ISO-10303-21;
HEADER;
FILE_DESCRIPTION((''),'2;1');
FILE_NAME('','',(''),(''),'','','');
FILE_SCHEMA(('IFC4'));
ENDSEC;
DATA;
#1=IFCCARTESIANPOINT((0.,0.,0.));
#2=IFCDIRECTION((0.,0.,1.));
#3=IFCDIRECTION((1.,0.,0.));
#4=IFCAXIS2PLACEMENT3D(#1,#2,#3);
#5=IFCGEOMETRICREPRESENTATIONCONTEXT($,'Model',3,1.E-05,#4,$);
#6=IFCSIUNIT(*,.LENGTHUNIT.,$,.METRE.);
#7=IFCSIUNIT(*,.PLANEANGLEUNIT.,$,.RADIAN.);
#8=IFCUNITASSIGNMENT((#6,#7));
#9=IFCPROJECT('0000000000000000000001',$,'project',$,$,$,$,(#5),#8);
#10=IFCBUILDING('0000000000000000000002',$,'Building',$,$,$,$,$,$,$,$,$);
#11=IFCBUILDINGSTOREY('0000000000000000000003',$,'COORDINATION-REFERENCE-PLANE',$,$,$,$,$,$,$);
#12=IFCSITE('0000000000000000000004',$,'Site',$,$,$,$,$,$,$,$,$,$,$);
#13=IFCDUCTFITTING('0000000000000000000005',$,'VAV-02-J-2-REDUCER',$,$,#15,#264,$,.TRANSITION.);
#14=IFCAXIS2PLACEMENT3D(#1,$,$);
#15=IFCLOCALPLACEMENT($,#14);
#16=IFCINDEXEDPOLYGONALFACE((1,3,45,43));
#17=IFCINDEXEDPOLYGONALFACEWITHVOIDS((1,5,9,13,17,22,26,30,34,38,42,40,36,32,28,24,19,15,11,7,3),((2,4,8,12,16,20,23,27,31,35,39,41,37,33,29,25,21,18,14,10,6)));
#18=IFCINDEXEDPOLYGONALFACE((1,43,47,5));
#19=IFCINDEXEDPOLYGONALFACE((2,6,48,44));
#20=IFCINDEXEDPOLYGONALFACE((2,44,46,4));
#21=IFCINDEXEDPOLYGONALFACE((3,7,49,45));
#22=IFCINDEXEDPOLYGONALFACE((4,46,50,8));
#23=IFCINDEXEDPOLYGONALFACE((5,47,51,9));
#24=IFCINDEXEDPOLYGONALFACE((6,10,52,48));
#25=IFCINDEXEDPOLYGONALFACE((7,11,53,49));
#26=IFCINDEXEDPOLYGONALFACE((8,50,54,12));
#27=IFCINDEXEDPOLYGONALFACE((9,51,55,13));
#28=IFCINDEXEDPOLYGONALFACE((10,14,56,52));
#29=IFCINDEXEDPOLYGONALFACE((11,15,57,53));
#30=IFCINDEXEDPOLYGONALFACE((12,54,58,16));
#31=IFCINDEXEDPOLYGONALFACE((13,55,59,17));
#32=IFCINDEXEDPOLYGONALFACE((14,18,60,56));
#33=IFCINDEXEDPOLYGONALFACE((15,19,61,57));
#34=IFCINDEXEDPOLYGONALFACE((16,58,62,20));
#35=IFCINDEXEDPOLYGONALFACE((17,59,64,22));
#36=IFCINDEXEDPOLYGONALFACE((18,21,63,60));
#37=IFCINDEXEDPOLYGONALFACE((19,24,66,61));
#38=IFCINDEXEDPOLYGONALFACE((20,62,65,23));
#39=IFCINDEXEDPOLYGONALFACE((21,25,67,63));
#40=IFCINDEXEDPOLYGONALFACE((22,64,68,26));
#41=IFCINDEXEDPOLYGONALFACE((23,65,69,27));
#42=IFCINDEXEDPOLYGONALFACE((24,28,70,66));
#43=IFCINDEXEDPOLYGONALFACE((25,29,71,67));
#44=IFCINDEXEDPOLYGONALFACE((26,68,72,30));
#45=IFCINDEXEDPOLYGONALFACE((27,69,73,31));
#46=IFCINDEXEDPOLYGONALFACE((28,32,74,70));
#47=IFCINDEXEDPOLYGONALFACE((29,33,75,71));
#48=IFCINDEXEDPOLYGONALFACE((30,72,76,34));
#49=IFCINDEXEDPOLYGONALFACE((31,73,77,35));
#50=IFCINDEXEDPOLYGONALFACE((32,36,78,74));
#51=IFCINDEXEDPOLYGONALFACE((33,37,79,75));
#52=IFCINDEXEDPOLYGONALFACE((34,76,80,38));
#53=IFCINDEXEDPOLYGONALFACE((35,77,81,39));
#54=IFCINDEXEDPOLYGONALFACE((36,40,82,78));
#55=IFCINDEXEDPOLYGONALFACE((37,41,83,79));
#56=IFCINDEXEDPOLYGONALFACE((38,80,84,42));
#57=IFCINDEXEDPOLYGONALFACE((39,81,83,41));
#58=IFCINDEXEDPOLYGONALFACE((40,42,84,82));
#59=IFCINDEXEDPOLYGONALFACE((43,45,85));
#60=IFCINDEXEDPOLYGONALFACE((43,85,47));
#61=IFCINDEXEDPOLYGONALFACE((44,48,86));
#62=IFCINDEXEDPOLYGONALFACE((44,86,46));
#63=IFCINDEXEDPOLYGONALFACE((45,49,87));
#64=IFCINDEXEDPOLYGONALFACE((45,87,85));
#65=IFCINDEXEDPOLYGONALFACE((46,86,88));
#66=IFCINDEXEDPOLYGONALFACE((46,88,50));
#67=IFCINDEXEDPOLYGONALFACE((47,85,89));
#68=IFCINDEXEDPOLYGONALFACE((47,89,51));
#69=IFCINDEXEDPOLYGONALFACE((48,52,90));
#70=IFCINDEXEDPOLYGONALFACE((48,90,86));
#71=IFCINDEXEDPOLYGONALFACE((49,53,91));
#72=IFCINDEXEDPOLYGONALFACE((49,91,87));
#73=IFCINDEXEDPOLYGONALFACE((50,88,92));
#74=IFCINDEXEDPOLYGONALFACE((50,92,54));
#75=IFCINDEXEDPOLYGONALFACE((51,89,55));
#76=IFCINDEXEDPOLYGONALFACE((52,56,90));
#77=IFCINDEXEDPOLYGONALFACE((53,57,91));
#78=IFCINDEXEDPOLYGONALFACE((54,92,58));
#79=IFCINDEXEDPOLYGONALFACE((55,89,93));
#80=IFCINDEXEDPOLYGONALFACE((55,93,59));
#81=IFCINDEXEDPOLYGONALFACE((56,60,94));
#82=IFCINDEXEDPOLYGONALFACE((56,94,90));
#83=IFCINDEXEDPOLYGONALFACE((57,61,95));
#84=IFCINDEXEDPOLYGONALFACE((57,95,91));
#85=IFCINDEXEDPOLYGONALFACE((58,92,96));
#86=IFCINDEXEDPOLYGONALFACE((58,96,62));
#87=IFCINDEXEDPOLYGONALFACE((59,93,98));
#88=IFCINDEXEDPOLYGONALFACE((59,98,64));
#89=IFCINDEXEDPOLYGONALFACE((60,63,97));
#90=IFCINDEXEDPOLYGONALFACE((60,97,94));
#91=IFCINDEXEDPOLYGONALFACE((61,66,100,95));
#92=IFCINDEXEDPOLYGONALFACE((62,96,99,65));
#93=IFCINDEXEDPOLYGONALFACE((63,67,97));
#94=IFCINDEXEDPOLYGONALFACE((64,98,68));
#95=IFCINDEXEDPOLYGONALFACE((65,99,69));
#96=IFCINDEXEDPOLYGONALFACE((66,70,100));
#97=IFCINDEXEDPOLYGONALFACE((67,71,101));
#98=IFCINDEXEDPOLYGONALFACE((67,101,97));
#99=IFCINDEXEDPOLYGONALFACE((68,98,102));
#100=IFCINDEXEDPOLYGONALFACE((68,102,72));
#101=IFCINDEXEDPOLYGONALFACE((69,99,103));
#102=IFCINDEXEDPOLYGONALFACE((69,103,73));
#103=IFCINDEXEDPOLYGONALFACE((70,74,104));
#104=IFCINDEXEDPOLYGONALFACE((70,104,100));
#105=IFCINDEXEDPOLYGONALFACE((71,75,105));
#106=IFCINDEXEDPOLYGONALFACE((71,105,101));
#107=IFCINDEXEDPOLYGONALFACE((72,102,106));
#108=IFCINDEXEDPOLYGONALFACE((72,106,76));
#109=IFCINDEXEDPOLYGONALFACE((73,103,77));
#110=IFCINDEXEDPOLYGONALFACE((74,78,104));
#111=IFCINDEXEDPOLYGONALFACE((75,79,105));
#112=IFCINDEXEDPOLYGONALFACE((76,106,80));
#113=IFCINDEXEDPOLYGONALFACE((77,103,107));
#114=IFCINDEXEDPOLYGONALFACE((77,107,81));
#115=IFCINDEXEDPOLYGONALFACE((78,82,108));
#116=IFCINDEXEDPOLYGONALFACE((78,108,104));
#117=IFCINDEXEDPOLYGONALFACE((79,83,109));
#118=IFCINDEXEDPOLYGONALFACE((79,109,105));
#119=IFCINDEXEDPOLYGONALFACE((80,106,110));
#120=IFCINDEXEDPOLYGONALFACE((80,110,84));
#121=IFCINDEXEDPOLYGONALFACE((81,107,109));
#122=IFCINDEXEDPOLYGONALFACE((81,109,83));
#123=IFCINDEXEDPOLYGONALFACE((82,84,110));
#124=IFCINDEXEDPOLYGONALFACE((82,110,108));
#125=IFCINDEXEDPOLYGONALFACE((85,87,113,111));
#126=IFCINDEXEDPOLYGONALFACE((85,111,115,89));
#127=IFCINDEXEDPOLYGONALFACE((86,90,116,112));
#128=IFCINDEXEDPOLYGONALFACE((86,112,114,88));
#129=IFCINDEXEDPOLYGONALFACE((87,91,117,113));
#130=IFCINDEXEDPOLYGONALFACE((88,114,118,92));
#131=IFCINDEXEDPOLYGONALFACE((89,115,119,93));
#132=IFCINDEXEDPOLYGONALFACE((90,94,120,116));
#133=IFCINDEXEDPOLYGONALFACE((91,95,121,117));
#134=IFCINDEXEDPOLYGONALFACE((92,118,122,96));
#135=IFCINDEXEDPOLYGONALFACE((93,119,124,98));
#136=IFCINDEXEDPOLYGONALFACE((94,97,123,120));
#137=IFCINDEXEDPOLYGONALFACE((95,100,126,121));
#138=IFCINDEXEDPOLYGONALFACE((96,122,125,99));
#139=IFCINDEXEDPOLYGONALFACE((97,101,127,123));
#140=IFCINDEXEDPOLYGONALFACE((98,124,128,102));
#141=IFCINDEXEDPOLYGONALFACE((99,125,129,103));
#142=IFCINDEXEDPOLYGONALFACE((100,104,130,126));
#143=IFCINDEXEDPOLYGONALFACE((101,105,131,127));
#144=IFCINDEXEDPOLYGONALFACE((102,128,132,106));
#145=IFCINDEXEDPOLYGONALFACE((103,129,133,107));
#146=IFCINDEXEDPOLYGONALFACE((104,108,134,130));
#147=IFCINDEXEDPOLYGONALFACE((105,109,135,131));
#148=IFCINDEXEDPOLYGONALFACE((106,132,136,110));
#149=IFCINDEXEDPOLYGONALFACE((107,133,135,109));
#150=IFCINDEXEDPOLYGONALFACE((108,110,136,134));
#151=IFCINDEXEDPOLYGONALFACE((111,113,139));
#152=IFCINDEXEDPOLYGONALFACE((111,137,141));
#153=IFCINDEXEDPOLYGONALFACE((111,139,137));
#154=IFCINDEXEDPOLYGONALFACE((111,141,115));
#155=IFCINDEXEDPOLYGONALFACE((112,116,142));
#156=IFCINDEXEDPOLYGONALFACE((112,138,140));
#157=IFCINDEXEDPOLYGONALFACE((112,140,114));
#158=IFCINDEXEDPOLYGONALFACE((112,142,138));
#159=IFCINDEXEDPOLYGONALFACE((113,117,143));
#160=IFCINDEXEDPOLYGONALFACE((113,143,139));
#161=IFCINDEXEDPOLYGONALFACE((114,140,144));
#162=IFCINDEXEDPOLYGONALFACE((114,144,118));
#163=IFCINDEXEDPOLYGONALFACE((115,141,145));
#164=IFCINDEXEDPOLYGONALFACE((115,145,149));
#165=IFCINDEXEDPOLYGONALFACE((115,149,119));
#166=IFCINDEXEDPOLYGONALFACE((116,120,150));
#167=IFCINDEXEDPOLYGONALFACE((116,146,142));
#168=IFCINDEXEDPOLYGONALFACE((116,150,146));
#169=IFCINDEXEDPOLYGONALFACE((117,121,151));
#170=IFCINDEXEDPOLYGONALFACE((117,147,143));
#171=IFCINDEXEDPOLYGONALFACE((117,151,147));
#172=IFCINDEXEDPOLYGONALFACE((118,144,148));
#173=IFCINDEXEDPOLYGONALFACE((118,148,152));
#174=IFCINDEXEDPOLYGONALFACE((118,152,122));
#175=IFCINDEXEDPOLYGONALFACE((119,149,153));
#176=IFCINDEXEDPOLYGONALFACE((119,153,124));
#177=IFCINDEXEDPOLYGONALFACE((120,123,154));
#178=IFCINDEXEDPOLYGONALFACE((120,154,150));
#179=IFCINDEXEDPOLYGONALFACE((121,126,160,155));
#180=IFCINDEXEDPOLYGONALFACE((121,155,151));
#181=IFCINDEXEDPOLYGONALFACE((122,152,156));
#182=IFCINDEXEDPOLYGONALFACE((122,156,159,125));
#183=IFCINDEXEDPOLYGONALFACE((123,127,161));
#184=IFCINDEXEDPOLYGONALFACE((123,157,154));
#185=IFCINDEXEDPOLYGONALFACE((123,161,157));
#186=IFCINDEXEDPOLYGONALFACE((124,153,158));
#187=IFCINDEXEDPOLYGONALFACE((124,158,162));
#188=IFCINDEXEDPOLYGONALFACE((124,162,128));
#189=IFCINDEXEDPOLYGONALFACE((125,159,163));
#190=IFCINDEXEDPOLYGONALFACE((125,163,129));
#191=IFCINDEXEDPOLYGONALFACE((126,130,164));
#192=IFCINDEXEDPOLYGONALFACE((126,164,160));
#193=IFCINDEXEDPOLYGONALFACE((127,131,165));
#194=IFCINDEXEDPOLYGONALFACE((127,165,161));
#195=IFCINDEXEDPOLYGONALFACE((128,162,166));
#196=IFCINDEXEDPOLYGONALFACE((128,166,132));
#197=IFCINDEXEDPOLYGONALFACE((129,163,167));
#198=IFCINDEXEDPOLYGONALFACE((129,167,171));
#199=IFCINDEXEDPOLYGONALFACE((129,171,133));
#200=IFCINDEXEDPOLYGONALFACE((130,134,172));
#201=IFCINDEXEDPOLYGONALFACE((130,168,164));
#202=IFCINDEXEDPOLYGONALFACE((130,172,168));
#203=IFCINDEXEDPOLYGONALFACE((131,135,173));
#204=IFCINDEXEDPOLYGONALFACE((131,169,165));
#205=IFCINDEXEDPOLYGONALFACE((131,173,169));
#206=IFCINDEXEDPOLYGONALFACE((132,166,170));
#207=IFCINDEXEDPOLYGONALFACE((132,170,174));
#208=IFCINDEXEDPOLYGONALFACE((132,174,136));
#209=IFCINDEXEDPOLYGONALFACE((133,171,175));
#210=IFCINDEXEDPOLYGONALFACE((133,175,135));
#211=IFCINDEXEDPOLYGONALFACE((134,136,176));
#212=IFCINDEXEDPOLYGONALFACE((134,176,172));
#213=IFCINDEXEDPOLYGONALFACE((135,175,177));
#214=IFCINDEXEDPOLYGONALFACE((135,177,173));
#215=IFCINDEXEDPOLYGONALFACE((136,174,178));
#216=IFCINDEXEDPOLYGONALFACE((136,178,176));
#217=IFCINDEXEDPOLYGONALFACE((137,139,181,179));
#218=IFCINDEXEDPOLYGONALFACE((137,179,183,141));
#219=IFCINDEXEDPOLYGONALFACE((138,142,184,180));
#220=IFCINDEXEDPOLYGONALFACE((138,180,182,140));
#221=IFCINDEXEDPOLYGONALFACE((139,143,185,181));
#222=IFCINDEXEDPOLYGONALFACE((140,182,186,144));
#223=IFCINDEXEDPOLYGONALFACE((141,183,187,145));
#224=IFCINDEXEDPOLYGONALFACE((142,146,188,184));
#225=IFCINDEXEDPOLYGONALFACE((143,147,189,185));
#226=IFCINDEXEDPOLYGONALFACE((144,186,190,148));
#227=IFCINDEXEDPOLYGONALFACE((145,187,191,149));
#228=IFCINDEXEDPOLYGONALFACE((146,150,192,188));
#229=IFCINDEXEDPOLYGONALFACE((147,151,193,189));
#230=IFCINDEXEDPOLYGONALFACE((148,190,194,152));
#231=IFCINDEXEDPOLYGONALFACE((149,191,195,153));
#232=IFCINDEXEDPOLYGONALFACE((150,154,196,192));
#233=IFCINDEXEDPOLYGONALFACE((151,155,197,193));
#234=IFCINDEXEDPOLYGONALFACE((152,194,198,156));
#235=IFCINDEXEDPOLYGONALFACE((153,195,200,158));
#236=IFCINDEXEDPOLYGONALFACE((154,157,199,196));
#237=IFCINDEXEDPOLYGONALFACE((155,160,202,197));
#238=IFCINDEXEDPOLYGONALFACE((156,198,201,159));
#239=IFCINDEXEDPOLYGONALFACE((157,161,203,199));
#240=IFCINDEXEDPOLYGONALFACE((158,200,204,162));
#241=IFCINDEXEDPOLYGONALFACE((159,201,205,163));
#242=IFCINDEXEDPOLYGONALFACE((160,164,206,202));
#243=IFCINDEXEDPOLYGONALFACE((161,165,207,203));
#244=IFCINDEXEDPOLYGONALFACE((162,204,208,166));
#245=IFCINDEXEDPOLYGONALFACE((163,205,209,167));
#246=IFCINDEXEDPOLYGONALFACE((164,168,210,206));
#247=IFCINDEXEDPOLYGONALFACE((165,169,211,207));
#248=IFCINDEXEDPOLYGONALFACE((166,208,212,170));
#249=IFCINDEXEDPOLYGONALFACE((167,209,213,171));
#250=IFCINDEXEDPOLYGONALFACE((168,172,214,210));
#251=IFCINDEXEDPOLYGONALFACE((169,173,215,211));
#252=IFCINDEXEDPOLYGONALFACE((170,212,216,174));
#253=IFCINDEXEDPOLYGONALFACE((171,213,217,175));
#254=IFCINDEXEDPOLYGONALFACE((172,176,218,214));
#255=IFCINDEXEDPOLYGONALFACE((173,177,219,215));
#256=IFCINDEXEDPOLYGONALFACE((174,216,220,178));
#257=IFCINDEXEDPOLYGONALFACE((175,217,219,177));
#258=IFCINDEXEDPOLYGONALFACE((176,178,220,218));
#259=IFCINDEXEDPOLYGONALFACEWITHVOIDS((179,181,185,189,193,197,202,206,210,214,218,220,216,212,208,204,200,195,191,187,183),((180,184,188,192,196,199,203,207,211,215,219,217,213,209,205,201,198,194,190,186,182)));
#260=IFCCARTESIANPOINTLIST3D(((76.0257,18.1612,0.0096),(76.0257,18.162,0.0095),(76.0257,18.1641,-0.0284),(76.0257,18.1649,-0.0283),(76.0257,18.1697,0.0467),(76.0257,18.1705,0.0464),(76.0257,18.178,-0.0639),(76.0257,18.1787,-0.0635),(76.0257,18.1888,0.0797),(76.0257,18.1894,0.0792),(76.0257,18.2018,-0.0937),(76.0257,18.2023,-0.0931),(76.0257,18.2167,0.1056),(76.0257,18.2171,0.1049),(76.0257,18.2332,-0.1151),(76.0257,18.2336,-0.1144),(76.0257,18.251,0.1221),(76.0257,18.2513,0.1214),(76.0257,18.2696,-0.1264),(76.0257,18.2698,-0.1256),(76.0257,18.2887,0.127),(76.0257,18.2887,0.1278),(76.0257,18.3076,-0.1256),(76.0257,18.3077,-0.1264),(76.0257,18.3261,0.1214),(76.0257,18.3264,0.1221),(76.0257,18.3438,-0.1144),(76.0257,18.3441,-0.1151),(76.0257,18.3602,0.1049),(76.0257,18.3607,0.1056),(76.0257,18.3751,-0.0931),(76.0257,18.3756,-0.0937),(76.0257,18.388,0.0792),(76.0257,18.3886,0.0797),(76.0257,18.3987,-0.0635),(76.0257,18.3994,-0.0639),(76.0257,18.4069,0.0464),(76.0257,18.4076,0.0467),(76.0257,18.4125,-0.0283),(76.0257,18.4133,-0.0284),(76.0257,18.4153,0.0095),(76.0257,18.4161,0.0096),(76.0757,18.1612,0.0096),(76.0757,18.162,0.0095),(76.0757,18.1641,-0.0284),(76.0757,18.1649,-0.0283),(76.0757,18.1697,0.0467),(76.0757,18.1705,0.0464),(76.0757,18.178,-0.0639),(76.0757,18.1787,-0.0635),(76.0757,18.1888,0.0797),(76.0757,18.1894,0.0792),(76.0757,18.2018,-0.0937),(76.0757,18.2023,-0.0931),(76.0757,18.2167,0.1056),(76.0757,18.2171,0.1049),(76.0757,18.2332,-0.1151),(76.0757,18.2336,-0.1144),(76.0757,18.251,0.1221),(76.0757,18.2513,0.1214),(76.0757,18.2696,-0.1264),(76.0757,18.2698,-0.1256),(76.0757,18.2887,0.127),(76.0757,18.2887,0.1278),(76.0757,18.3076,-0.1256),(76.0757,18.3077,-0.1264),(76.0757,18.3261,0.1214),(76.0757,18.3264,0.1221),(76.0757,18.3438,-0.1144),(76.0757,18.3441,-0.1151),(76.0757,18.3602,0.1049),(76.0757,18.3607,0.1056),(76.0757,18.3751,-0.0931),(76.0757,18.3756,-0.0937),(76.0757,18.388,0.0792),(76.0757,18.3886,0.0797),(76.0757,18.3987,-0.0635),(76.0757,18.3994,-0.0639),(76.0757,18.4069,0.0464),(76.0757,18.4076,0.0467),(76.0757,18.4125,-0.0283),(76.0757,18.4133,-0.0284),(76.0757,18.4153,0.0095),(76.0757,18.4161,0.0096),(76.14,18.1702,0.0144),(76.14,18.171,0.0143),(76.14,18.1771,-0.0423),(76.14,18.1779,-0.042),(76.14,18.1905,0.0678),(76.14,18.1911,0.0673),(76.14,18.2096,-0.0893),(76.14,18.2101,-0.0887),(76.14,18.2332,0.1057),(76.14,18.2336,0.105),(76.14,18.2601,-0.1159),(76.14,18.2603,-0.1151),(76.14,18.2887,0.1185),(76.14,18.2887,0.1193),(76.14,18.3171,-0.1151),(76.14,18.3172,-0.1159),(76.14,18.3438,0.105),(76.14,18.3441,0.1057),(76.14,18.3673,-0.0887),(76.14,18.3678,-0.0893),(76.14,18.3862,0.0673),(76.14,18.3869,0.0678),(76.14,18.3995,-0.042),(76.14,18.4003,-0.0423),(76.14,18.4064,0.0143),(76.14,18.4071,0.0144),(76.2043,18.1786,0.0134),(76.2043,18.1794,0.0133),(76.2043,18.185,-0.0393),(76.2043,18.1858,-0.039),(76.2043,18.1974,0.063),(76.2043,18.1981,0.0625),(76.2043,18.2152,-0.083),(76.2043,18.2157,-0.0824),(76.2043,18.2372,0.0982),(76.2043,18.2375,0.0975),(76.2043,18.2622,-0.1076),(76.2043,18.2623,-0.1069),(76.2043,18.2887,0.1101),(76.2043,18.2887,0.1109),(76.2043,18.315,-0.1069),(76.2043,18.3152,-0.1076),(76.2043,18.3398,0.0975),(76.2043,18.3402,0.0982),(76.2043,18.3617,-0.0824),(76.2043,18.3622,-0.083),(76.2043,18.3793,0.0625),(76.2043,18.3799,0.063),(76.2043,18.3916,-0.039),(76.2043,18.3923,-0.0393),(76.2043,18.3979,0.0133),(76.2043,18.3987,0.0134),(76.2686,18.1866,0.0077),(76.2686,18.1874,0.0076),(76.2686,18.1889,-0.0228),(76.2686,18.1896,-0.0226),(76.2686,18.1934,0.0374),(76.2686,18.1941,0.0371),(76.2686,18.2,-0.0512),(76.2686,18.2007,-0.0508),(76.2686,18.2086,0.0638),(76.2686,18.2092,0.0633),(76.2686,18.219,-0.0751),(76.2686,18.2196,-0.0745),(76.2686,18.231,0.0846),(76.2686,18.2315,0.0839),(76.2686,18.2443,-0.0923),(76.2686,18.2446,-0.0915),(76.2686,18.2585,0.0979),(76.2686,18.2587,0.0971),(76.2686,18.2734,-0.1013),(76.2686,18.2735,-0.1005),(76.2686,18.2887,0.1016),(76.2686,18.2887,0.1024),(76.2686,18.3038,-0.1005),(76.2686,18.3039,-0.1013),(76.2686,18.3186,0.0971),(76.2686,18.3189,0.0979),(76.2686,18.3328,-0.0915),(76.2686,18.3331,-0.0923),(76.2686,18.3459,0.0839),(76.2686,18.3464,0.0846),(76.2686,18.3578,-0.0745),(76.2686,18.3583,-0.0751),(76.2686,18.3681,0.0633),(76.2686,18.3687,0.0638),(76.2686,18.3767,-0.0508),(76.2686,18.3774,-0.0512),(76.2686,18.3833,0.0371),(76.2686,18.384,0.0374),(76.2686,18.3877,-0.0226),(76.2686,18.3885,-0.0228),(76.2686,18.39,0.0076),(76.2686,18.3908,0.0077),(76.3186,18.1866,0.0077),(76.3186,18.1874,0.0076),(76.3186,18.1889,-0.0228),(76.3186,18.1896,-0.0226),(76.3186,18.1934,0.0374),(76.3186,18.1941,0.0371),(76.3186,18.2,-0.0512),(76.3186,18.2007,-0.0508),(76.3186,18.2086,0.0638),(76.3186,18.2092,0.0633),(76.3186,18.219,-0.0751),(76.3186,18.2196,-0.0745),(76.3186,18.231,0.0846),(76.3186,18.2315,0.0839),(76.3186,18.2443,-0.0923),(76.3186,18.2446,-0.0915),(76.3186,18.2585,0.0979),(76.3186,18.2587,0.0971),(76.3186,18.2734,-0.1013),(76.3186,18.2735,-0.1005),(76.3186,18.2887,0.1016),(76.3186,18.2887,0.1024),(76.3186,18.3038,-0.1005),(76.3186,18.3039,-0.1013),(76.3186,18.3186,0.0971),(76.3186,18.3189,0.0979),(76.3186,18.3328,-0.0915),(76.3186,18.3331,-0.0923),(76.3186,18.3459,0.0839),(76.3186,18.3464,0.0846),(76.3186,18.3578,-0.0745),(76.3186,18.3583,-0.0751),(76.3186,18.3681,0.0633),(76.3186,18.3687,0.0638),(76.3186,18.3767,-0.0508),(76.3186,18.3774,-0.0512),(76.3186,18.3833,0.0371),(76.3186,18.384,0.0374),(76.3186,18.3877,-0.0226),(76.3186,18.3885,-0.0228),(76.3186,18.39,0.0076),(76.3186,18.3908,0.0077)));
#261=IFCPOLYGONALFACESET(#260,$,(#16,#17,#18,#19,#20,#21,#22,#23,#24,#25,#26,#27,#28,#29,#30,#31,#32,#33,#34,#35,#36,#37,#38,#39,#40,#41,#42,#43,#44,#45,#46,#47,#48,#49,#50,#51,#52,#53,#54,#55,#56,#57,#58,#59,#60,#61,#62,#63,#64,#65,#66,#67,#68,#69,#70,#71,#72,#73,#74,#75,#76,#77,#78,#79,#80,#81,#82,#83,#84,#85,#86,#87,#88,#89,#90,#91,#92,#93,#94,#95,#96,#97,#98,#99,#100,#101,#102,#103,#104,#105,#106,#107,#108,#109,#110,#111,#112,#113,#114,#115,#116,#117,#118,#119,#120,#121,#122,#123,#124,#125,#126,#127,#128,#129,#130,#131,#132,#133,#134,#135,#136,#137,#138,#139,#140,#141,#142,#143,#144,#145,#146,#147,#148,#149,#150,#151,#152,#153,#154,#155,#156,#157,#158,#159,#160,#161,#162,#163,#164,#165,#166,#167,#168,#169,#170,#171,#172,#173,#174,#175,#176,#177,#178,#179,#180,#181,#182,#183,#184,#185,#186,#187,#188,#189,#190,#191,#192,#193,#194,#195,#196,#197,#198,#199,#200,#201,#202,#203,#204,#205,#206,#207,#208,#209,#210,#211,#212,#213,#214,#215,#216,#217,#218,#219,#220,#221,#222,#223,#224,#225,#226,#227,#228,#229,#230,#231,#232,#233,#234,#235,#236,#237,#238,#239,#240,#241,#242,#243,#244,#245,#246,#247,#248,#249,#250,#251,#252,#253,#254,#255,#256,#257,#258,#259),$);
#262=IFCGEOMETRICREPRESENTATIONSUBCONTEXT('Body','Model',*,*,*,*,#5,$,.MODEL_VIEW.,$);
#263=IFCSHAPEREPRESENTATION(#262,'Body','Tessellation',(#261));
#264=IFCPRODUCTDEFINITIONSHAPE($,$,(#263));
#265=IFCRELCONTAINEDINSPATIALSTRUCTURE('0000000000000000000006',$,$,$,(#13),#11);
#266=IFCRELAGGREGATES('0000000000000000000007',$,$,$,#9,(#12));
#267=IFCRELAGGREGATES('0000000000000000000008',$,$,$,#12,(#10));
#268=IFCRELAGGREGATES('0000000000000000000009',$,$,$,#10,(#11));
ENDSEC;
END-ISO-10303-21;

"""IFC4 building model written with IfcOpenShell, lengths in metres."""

from ifc_helpers import new_model, entity, si_unit, frame, origin_with_axes, place, context, subcontext, project, spatial, element, save


model = new_model("IFC4")

# Units and contexts
model_context_1 = context("Model", 3, precision=1e-05, world=origin_with_axes())
body_context_1 = subcontext(model_context_1, "Body", "Model", "MODEL_VIEW")
ifc_project = project(units=[si_unit("LENGTHUNIT", "METRE"), si_unit("PLANEANGLEUNIT", "RADIAN")], contexts=[model_context_1])

# Site, building, storey
site = spatial("IfcSite", under=ifc_project, Name="Site")
building = spatial("IfcBuilding", under=site, Name="Building")
storey = spatial("IfcBuildingStorey", under=building, Name="COORDINATION-REFERENCE-PLANE")

# Duct fitting
for number, where, z_axis, x_axis, name in (
    (1, (76.0257, 18.2887, 0.0), (0.0, 1.0, 0.0), (0.0, 0.0, 1.0), "VAV-02-J-2-REDUCER"),
):
    element("IfcDuctFitting", number, at=place(None, frame(where, z_axis=z_axis, x_axis=x_axis)), inside=storey, Name=name, PredefinedType="TRANSITION", context=body_context_1, shape_type="SweptSolid", body=[
        entity("IfcRevolvedAreaSolid", entity("IfcArbitraryClosedProfileDef", "AREA", None, entity("IfcPolyline", [entity("IfcCartesianPoint", [0.1278, 0.0]), entity("IfcCartesianPoint", [0.1278, 0.05]), entity("IfcCartesianPoint", [0.1024, 0.2429]), entity("IfcCartesianPoint", [0.1024, 0.2929]), entity("IfcCartesianPoint", [0.1016, 0.2929]), entity("IfcCartesianPoint", [0.1016, 0.2429]), entity("IfcCartesianPoint", [0.127, 0.05]), entity("IfcCartesianPoint", [0.127, 0.0]), entity("IfcCartesianPoint", [0.1278, 0.0])])), entity("IfcAxis2Placement3D", entity("IfcCartesianPoint", [0.0, 0.0, 0.0])), entity("IfcAxis1Placement", entity("IfcCartesianPoint", [0.0, 0.0, 0.0]), entity("IfcDirection", [0.0, 1.0, 0.0])), 6.283185),
    ])

save(model, "model.ifc")
